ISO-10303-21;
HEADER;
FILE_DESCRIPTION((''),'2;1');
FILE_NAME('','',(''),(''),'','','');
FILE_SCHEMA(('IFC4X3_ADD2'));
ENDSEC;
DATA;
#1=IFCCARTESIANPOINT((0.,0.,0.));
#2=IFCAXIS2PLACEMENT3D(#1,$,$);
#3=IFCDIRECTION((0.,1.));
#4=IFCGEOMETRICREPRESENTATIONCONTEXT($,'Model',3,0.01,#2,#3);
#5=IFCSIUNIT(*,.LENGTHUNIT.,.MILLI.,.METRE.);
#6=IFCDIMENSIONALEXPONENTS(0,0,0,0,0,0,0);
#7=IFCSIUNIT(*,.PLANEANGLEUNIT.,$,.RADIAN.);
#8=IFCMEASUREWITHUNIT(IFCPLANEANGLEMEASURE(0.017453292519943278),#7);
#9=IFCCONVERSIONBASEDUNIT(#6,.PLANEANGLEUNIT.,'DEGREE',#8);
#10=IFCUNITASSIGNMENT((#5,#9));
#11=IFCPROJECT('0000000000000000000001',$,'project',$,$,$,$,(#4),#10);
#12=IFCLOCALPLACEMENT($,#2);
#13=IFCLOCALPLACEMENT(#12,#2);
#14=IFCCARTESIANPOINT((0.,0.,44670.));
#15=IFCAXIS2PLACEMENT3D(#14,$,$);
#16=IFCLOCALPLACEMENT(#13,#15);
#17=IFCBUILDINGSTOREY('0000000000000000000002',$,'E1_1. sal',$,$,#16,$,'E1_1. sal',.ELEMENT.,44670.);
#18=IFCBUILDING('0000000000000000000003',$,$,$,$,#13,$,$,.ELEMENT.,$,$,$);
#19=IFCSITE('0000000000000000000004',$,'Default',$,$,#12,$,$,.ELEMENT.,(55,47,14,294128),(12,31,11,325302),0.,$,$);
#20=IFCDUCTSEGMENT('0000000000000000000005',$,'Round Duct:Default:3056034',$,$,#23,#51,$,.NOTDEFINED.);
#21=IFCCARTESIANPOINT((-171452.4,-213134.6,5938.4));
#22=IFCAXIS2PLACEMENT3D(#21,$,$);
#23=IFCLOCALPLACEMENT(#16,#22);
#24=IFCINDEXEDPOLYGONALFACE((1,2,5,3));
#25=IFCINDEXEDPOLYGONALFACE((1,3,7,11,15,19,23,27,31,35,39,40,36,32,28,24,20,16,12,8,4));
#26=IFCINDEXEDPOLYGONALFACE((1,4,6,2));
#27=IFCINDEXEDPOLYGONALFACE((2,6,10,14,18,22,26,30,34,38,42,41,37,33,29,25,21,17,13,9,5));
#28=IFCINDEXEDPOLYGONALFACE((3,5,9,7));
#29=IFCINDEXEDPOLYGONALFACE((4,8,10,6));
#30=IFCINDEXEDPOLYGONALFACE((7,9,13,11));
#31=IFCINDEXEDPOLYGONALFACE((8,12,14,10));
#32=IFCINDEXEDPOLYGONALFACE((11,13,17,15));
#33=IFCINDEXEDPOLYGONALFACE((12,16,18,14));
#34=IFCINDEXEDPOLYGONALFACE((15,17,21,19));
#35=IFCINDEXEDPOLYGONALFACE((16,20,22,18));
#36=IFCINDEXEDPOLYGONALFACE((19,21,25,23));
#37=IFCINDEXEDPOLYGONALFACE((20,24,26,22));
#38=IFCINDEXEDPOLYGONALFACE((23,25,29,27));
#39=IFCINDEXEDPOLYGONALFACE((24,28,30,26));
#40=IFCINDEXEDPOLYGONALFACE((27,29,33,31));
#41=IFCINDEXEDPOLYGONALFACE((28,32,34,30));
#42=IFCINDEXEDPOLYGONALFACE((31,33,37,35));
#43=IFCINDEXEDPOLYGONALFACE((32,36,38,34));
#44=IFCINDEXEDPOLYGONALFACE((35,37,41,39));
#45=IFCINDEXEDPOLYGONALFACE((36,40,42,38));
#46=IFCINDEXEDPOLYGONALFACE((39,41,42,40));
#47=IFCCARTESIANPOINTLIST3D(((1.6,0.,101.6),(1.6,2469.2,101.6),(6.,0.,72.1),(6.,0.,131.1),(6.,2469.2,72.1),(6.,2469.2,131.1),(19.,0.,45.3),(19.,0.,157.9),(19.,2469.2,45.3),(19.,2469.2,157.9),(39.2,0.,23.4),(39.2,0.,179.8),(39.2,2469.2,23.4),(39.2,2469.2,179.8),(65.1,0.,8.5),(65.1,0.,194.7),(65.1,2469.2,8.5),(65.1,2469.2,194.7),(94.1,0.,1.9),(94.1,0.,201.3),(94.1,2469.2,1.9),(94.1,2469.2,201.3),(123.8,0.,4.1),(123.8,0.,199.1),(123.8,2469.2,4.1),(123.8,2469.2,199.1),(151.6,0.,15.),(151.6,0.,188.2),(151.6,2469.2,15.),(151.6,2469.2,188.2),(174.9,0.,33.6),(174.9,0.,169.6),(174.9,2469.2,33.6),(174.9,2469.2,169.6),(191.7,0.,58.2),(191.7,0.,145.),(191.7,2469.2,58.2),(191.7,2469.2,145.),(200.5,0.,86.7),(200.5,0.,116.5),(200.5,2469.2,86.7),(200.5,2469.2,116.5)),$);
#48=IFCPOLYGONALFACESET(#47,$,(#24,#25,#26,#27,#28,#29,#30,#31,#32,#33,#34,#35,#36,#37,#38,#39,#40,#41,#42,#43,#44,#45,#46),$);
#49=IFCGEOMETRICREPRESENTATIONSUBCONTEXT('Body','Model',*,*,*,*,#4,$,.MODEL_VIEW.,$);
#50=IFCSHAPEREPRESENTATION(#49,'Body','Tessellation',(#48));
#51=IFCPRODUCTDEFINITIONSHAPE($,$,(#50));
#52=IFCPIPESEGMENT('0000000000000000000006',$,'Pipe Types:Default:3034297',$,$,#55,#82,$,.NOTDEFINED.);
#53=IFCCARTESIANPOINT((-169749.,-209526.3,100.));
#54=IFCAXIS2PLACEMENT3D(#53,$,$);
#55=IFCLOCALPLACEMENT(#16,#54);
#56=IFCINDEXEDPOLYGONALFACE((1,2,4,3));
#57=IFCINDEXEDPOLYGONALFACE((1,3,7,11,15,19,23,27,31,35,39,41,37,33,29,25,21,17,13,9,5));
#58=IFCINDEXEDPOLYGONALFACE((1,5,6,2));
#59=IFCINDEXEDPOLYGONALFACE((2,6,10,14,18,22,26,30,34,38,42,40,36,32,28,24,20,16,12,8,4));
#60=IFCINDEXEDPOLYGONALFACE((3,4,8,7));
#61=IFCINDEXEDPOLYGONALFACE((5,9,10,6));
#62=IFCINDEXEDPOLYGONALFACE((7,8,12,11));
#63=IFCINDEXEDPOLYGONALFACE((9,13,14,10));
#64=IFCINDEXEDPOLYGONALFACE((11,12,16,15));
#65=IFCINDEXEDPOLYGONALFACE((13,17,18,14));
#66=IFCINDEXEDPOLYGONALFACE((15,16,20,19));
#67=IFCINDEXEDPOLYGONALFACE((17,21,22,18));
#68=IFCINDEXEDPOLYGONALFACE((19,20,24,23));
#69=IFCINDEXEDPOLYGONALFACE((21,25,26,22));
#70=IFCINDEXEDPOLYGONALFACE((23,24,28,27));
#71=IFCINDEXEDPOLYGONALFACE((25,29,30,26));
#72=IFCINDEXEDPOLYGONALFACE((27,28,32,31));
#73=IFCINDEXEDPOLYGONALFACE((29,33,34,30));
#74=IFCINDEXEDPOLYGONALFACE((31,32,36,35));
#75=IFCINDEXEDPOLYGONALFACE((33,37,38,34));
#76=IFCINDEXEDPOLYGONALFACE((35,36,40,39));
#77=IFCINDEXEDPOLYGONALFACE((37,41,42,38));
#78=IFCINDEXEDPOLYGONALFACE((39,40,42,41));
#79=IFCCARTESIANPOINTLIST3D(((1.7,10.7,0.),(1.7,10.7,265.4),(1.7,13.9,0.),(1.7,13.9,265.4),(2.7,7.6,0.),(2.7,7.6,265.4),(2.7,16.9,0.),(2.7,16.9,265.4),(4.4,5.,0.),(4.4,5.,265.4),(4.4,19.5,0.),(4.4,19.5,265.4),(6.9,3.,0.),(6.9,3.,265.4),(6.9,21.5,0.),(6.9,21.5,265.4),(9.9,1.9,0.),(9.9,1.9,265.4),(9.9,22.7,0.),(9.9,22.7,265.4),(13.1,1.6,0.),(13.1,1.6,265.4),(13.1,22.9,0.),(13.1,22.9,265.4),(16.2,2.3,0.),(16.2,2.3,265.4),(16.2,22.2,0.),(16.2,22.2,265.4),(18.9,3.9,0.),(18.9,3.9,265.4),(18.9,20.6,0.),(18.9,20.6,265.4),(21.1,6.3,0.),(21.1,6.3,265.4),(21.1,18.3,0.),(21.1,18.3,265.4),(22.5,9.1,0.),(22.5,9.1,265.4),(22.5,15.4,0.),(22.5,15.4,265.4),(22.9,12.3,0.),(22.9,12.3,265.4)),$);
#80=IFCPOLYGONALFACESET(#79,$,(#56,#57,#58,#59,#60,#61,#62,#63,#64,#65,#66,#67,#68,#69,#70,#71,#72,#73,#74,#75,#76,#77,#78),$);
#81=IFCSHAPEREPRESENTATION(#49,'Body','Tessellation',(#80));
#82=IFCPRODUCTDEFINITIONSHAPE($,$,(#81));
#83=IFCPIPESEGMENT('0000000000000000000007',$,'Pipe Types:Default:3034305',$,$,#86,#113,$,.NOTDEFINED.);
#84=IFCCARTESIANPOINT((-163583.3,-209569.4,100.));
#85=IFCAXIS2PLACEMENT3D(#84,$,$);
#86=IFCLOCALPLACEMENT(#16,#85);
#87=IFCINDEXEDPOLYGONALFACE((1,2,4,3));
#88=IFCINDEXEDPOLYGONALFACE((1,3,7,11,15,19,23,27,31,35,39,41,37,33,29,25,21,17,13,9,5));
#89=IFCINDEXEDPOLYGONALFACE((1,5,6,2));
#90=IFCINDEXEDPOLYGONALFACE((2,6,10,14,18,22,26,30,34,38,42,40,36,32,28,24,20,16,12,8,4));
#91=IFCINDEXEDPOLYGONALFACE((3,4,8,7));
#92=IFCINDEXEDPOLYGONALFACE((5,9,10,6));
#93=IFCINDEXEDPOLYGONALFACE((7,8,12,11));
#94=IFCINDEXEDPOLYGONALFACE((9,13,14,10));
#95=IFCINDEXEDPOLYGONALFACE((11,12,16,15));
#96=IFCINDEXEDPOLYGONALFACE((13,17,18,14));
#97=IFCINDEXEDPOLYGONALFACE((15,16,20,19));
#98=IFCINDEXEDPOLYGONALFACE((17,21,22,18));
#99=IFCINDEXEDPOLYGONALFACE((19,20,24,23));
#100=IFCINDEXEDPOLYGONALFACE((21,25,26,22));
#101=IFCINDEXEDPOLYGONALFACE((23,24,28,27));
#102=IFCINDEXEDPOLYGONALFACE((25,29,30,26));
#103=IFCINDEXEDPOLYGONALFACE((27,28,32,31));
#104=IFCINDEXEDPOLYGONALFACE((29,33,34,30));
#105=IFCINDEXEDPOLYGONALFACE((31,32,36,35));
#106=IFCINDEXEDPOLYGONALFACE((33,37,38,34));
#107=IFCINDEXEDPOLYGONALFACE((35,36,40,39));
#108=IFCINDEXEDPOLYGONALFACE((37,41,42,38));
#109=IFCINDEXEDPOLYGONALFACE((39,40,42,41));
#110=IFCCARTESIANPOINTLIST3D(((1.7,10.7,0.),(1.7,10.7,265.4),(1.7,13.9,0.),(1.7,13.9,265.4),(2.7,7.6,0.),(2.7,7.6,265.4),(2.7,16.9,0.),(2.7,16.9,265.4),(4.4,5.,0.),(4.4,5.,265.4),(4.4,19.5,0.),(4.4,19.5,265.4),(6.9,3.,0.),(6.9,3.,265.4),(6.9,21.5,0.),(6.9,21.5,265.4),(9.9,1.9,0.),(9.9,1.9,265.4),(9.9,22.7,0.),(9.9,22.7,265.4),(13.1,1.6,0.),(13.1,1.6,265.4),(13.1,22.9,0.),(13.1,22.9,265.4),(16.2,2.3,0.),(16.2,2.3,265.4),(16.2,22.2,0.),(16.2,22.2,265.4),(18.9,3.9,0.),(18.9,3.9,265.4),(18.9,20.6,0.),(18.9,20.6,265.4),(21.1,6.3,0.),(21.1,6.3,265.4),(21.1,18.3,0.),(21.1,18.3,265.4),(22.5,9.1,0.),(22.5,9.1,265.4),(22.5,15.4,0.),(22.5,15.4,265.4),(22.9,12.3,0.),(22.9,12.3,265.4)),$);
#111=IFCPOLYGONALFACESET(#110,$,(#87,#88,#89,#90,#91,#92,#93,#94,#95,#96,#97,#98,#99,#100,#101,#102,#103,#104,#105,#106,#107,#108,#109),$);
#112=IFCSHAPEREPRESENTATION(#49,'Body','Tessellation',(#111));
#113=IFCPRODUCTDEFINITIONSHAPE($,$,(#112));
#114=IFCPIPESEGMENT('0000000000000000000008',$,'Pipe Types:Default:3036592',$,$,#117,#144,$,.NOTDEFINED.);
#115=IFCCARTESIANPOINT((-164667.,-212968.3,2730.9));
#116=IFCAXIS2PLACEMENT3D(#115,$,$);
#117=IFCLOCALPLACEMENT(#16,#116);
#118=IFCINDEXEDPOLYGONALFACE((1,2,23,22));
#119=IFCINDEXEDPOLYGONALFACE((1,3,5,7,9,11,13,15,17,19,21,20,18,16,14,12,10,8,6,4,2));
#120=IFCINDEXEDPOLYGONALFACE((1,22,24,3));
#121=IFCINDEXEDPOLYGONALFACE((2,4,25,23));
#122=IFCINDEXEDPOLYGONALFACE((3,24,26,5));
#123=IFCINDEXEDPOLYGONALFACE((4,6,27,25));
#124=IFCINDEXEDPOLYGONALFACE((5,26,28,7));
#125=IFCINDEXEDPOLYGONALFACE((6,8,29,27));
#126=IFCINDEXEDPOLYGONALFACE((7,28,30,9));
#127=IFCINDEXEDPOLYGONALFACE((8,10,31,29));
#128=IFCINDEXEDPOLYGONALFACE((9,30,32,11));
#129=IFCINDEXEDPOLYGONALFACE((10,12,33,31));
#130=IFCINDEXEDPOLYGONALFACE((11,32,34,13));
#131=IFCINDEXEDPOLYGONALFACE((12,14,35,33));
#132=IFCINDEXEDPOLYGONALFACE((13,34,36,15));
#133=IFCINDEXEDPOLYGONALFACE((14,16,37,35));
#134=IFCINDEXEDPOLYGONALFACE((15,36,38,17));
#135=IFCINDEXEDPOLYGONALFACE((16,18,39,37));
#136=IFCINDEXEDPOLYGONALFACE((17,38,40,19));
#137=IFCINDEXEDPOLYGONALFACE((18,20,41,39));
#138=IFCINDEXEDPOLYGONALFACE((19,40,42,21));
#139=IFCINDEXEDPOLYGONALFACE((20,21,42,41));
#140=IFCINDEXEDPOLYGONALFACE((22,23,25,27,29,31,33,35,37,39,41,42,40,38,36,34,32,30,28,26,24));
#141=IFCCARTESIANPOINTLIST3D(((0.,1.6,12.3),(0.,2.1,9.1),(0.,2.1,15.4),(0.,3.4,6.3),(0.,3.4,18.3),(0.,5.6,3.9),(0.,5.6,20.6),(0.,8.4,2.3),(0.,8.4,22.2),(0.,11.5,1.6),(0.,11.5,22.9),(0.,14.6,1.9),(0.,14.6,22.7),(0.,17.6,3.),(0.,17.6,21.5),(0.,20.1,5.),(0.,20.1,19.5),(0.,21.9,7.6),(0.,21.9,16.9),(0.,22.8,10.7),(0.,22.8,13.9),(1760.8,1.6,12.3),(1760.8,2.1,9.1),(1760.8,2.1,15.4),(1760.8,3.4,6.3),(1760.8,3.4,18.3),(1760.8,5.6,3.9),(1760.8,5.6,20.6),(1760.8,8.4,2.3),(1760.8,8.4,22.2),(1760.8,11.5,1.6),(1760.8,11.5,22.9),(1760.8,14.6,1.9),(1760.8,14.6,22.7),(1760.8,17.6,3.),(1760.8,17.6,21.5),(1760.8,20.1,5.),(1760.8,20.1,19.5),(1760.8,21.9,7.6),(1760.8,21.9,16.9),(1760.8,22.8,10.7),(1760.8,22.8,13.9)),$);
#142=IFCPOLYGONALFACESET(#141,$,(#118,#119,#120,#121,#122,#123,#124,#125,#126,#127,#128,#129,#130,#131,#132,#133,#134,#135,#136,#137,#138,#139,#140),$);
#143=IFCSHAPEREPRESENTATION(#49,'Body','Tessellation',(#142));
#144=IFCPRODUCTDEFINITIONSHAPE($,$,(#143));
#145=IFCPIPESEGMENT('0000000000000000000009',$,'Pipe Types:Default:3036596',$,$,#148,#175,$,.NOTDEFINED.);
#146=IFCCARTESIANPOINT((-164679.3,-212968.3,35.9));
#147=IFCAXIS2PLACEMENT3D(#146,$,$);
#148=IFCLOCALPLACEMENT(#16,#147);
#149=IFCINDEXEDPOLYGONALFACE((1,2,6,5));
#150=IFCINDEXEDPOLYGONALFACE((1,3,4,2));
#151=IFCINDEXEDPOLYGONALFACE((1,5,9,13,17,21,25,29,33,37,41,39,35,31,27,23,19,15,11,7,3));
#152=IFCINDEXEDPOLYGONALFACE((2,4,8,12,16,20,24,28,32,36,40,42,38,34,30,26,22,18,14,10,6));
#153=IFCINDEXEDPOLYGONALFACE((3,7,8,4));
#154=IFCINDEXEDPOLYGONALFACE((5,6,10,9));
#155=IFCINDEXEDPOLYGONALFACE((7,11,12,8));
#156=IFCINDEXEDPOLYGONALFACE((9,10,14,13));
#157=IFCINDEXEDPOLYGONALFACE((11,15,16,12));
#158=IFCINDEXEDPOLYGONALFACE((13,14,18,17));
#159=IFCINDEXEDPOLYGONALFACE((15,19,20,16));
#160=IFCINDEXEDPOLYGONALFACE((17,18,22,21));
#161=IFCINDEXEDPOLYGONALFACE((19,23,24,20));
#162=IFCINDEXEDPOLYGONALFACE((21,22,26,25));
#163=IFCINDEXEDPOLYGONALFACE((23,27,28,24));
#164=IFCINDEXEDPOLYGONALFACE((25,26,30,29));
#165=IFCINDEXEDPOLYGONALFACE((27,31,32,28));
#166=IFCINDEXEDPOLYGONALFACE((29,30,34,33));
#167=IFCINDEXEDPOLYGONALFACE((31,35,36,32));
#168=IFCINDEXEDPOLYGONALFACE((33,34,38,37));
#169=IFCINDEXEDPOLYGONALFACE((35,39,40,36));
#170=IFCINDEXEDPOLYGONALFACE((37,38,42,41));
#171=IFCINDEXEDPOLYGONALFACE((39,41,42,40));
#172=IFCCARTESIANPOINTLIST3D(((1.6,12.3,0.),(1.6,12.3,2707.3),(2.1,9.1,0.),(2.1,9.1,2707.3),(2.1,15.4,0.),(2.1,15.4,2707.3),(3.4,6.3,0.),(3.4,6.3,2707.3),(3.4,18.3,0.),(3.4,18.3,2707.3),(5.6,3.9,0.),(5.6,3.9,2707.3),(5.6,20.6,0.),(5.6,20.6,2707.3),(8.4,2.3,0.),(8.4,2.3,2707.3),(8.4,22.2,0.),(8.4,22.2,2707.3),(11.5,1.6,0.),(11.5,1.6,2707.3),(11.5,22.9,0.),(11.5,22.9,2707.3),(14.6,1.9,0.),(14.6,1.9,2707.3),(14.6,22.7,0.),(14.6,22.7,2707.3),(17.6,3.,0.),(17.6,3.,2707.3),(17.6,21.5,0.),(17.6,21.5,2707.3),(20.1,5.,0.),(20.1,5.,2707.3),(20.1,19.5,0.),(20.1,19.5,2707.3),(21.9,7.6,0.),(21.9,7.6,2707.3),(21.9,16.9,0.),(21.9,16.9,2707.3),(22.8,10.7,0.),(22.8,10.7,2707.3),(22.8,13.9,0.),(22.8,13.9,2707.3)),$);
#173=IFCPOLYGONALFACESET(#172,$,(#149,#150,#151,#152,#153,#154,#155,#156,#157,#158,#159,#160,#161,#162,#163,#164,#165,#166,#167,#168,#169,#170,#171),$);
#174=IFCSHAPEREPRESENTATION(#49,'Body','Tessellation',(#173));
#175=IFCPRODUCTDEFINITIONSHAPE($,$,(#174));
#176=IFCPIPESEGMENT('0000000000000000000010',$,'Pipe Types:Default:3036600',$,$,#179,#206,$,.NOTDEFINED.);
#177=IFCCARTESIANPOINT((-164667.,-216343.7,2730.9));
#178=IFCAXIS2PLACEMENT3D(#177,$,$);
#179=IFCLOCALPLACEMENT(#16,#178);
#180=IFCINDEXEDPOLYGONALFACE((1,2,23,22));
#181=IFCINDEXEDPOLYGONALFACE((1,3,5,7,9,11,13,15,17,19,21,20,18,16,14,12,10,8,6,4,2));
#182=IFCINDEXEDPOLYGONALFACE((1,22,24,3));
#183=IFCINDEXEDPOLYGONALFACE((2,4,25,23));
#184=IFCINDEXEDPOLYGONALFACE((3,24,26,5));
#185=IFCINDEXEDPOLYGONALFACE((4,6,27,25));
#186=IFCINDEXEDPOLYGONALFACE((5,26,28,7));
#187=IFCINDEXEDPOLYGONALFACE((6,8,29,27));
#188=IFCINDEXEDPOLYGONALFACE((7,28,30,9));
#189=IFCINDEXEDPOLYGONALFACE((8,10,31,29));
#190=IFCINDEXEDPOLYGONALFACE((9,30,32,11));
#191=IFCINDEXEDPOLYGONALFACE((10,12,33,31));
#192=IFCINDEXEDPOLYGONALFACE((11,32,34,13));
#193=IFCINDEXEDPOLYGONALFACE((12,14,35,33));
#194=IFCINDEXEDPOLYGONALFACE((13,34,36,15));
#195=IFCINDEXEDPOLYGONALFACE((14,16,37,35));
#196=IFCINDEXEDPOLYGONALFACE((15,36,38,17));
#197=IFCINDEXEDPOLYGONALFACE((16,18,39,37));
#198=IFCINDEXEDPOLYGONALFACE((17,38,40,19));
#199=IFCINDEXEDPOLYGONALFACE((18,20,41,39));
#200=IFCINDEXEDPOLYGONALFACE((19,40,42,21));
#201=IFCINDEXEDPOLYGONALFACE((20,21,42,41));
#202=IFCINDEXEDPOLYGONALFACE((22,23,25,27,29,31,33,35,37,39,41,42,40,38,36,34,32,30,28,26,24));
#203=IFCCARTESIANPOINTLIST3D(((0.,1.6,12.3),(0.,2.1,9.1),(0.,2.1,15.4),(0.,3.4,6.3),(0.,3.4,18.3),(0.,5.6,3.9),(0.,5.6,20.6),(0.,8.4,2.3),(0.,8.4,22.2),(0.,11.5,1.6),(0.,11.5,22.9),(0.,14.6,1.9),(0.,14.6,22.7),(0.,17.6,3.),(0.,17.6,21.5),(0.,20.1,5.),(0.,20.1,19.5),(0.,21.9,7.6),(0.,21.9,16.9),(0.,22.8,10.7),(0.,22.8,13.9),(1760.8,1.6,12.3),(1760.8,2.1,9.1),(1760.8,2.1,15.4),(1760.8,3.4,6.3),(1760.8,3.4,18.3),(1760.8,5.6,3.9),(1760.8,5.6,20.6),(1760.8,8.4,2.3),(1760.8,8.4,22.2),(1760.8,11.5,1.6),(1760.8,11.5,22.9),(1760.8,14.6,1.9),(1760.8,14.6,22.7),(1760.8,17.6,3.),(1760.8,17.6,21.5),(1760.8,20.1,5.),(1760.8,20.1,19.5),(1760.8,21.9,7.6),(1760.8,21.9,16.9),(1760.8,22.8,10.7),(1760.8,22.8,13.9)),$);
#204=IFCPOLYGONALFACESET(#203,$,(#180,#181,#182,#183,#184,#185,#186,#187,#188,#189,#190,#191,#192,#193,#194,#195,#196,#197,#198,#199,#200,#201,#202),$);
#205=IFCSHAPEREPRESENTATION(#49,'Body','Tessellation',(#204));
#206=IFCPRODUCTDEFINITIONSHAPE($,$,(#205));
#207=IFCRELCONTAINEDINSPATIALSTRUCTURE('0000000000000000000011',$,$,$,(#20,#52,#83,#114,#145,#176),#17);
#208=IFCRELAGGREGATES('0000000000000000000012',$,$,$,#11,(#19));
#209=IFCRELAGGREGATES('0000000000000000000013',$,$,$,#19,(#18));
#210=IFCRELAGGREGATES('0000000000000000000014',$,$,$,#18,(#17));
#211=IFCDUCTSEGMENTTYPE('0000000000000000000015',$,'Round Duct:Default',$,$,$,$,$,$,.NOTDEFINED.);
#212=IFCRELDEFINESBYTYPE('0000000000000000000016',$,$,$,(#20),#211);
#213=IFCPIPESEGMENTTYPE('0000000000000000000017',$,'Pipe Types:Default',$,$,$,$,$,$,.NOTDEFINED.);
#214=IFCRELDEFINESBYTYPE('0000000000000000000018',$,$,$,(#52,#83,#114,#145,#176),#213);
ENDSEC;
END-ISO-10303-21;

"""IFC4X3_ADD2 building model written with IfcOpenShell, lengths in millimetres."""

from ifc_helpers import new_model, entity, si_unit, converted_unit, direction, frame, frame_2d, origin, origin_2d_with_axis, place, context, subcontext, project, spatial, circle, extrude, type_object, element, save


model = new_model("IFC4X3_ADD2")

# Units and contexts
model_context = context("Model", 3, precision=0.01, world=origin(), true_north=direction((0.0, 1.0)))
body_context = subcontext(model_context, "Body", "Model", "MODEL_VIEW")
ifc_project = project(units=[si_unit("LENGTHUNIT", "METRE", prefix="MILLI"), converted_unit("PLANEANGLEUNIT", "DEGREE", entity("IfcPlaneAngleMeasure", 0.017453292519943278), si_unit("PLANEANGLEUNIT", "RADIAN"), dimensions=[0, 0, 0, 0, 0, 0, 0])], contexts=[model_context])

# Site, building, storey
site_placement = place(None, origin())
site = spatial("IfcSite", under=ifc_project, at=site_placement, Name="Default", CompositionType="ELEMENT", RefLatitude=(55, 47, 14, 294128), RefLongitude=(12, 31, 11, 325302), RefElevation=0.0)
building_placement = place(site_placement, origin())
building = spatial("IfcBuilding", under=site, at=building_placement, CompositionType="ELEMENT")
storey_placement = place(building_placement, frame((0.0, 0.0, 44670.0)))
storey = spatial("IfcBuildingStorey", under=building, at=storey_placement, Name="E1_1. sal", LongName="E1_1. sal", CompositionType="ELEMENT", Elevation=44670.0)

# Duct segment
duct_segment_type = type_object("IfcDuctSegmentType", Name="Round Duct:Default", PredefinedType="NOTDEFINED")
duct_segment_1_placement = place(storey_placement, frame((-171452.4, -213134.6, 5938.4)))
element("IfcDuctSegment", 1, at=duct_segment_1_placement, inside=storey, type_object=duct_segment_type, Name="Round Duct:Default:3056034", PredefinedType="NOTDEFINED", context=body_context, shape_type="SweptSolid", body=[
    extrude(circle(Radius=100.0, at=origin_2d_with_axis()), frame((101.6, 0.0, 101.6), z_axis=(0.0, 1.0, 0.0), x_axis=(-1.0, 0.0, 0.0)), (0.0, 0.0, 1.0), 2469.2),
])

# Pipe segments
pipe_segment_type = type_object("IfcPipeSegmentType", Name="Pipe Types:Default", PredefinedType="NOTDEFINED")
pipe_segment_1_placement = place(storey_placement, frame((-169749.0, -209526.3, 100.0)))
element("IfcPipeSegment", 2, at=pipe_segment_1_placement, inside=storey, type_object=pipe_segment_type, Name="Pipe Types:Default:3034297", PredefinedType="NOTDEFINED", context=body_context, shape_type="SweptSolid", body=[
    extrude(circle(Radius=10.7, at=origin_2d_with_axis()), frame((12.3, 12.3, 0.0)), (0.0, 0.0, 1.0), 265.4),
])
pipe_segment_2_placement = place(storey_placement, frame((-163583.3, -209569.4, 100.0)))
element("IfcPipeSegment", 3, at=pipe_segment_2_placement, inside=storey, type_object=pipe_segment_type, Name="Pipe Types:Default:3034305", PredefinedType="NOTDEFINED", context=body_context, shape_type="SweptSolid", body=[
    extrude(circle(Radius=10.7, at=frame_2d((0.0, 0.0), x_axis=(1.0, 0.0))), frame((12.3, 12.3, 0.0)), (0.0, 0.0, 1.0), 265.4),
])
pipe_segment_3_placement = place(storey_placement, frame((-164667.0, -212968.3, 2730.9)))
element("IfcPipeSegment", 4, at=pipe_segment_3_placement, inside=storey, type_object=pipe_segment_type, Name="Pipe Types:Default:3036592", PredefinedType="NOTDEFINED", context=body_context, shape_type="SweptSolid", body=[
    extrude(circle(Radius=10.7, at=origin_2d_with_axis()), frame((0.0, 12.3, 12.3), z_axis=(1.0, 0.0, 0.0), x_axis=(0.0, -1.0, 0.0)), (0.0, 0.0, 1.0), 1760.8),
])
pipe_segment_4_placement = place(storey_placement, frame((-164679.3, -212968.3, 35.9)))
element("IfcPipeSegment", 5, at=pipe_segment_4_placement, inside=storey, type_object=pipe_segment_type, Name="Pipe Types:Default:3036596", PredefinedType="NOTDEFINED", context=body_context, shape_type="SweptSolid", body=[
    extrude(circle(Radius=10.7, at=frame_2d((0.0, 0.0), x_axis=(1.0, 0.0))), frame((12.3, 12.3, 0.0), z_axis=(0.0, 0.0, 1.0), x_axis=(-1.0, 0.0, 0.0)), (0.0, 0.0, 1.0), 2707.3),
])
pipe_segment_5_placement = place(storey_placement, frame((-164667.0, -216343.7, 2730.9)))
element("IfcPipeSegment", 6, at=pipe_segment_5_placement, inside=storey, type_object=pipe_segment_type, Name="Pipe Types:Default:3036600", PredefinedType="NOTDEFINED", context=body_context, shape_type="SweptSolid", body=[
    extrude(circle(Radius=10.7, at=origin_2d_with_axis()), frame((0.0, 12.3, 12.3), z_axis=(1.0, 0.0, 0.0), x_axis=(0.0, -1.0, 0.0)), (0.0, 0.0, 1.0), 1760.8),
])

save(model, "model.ifc")
